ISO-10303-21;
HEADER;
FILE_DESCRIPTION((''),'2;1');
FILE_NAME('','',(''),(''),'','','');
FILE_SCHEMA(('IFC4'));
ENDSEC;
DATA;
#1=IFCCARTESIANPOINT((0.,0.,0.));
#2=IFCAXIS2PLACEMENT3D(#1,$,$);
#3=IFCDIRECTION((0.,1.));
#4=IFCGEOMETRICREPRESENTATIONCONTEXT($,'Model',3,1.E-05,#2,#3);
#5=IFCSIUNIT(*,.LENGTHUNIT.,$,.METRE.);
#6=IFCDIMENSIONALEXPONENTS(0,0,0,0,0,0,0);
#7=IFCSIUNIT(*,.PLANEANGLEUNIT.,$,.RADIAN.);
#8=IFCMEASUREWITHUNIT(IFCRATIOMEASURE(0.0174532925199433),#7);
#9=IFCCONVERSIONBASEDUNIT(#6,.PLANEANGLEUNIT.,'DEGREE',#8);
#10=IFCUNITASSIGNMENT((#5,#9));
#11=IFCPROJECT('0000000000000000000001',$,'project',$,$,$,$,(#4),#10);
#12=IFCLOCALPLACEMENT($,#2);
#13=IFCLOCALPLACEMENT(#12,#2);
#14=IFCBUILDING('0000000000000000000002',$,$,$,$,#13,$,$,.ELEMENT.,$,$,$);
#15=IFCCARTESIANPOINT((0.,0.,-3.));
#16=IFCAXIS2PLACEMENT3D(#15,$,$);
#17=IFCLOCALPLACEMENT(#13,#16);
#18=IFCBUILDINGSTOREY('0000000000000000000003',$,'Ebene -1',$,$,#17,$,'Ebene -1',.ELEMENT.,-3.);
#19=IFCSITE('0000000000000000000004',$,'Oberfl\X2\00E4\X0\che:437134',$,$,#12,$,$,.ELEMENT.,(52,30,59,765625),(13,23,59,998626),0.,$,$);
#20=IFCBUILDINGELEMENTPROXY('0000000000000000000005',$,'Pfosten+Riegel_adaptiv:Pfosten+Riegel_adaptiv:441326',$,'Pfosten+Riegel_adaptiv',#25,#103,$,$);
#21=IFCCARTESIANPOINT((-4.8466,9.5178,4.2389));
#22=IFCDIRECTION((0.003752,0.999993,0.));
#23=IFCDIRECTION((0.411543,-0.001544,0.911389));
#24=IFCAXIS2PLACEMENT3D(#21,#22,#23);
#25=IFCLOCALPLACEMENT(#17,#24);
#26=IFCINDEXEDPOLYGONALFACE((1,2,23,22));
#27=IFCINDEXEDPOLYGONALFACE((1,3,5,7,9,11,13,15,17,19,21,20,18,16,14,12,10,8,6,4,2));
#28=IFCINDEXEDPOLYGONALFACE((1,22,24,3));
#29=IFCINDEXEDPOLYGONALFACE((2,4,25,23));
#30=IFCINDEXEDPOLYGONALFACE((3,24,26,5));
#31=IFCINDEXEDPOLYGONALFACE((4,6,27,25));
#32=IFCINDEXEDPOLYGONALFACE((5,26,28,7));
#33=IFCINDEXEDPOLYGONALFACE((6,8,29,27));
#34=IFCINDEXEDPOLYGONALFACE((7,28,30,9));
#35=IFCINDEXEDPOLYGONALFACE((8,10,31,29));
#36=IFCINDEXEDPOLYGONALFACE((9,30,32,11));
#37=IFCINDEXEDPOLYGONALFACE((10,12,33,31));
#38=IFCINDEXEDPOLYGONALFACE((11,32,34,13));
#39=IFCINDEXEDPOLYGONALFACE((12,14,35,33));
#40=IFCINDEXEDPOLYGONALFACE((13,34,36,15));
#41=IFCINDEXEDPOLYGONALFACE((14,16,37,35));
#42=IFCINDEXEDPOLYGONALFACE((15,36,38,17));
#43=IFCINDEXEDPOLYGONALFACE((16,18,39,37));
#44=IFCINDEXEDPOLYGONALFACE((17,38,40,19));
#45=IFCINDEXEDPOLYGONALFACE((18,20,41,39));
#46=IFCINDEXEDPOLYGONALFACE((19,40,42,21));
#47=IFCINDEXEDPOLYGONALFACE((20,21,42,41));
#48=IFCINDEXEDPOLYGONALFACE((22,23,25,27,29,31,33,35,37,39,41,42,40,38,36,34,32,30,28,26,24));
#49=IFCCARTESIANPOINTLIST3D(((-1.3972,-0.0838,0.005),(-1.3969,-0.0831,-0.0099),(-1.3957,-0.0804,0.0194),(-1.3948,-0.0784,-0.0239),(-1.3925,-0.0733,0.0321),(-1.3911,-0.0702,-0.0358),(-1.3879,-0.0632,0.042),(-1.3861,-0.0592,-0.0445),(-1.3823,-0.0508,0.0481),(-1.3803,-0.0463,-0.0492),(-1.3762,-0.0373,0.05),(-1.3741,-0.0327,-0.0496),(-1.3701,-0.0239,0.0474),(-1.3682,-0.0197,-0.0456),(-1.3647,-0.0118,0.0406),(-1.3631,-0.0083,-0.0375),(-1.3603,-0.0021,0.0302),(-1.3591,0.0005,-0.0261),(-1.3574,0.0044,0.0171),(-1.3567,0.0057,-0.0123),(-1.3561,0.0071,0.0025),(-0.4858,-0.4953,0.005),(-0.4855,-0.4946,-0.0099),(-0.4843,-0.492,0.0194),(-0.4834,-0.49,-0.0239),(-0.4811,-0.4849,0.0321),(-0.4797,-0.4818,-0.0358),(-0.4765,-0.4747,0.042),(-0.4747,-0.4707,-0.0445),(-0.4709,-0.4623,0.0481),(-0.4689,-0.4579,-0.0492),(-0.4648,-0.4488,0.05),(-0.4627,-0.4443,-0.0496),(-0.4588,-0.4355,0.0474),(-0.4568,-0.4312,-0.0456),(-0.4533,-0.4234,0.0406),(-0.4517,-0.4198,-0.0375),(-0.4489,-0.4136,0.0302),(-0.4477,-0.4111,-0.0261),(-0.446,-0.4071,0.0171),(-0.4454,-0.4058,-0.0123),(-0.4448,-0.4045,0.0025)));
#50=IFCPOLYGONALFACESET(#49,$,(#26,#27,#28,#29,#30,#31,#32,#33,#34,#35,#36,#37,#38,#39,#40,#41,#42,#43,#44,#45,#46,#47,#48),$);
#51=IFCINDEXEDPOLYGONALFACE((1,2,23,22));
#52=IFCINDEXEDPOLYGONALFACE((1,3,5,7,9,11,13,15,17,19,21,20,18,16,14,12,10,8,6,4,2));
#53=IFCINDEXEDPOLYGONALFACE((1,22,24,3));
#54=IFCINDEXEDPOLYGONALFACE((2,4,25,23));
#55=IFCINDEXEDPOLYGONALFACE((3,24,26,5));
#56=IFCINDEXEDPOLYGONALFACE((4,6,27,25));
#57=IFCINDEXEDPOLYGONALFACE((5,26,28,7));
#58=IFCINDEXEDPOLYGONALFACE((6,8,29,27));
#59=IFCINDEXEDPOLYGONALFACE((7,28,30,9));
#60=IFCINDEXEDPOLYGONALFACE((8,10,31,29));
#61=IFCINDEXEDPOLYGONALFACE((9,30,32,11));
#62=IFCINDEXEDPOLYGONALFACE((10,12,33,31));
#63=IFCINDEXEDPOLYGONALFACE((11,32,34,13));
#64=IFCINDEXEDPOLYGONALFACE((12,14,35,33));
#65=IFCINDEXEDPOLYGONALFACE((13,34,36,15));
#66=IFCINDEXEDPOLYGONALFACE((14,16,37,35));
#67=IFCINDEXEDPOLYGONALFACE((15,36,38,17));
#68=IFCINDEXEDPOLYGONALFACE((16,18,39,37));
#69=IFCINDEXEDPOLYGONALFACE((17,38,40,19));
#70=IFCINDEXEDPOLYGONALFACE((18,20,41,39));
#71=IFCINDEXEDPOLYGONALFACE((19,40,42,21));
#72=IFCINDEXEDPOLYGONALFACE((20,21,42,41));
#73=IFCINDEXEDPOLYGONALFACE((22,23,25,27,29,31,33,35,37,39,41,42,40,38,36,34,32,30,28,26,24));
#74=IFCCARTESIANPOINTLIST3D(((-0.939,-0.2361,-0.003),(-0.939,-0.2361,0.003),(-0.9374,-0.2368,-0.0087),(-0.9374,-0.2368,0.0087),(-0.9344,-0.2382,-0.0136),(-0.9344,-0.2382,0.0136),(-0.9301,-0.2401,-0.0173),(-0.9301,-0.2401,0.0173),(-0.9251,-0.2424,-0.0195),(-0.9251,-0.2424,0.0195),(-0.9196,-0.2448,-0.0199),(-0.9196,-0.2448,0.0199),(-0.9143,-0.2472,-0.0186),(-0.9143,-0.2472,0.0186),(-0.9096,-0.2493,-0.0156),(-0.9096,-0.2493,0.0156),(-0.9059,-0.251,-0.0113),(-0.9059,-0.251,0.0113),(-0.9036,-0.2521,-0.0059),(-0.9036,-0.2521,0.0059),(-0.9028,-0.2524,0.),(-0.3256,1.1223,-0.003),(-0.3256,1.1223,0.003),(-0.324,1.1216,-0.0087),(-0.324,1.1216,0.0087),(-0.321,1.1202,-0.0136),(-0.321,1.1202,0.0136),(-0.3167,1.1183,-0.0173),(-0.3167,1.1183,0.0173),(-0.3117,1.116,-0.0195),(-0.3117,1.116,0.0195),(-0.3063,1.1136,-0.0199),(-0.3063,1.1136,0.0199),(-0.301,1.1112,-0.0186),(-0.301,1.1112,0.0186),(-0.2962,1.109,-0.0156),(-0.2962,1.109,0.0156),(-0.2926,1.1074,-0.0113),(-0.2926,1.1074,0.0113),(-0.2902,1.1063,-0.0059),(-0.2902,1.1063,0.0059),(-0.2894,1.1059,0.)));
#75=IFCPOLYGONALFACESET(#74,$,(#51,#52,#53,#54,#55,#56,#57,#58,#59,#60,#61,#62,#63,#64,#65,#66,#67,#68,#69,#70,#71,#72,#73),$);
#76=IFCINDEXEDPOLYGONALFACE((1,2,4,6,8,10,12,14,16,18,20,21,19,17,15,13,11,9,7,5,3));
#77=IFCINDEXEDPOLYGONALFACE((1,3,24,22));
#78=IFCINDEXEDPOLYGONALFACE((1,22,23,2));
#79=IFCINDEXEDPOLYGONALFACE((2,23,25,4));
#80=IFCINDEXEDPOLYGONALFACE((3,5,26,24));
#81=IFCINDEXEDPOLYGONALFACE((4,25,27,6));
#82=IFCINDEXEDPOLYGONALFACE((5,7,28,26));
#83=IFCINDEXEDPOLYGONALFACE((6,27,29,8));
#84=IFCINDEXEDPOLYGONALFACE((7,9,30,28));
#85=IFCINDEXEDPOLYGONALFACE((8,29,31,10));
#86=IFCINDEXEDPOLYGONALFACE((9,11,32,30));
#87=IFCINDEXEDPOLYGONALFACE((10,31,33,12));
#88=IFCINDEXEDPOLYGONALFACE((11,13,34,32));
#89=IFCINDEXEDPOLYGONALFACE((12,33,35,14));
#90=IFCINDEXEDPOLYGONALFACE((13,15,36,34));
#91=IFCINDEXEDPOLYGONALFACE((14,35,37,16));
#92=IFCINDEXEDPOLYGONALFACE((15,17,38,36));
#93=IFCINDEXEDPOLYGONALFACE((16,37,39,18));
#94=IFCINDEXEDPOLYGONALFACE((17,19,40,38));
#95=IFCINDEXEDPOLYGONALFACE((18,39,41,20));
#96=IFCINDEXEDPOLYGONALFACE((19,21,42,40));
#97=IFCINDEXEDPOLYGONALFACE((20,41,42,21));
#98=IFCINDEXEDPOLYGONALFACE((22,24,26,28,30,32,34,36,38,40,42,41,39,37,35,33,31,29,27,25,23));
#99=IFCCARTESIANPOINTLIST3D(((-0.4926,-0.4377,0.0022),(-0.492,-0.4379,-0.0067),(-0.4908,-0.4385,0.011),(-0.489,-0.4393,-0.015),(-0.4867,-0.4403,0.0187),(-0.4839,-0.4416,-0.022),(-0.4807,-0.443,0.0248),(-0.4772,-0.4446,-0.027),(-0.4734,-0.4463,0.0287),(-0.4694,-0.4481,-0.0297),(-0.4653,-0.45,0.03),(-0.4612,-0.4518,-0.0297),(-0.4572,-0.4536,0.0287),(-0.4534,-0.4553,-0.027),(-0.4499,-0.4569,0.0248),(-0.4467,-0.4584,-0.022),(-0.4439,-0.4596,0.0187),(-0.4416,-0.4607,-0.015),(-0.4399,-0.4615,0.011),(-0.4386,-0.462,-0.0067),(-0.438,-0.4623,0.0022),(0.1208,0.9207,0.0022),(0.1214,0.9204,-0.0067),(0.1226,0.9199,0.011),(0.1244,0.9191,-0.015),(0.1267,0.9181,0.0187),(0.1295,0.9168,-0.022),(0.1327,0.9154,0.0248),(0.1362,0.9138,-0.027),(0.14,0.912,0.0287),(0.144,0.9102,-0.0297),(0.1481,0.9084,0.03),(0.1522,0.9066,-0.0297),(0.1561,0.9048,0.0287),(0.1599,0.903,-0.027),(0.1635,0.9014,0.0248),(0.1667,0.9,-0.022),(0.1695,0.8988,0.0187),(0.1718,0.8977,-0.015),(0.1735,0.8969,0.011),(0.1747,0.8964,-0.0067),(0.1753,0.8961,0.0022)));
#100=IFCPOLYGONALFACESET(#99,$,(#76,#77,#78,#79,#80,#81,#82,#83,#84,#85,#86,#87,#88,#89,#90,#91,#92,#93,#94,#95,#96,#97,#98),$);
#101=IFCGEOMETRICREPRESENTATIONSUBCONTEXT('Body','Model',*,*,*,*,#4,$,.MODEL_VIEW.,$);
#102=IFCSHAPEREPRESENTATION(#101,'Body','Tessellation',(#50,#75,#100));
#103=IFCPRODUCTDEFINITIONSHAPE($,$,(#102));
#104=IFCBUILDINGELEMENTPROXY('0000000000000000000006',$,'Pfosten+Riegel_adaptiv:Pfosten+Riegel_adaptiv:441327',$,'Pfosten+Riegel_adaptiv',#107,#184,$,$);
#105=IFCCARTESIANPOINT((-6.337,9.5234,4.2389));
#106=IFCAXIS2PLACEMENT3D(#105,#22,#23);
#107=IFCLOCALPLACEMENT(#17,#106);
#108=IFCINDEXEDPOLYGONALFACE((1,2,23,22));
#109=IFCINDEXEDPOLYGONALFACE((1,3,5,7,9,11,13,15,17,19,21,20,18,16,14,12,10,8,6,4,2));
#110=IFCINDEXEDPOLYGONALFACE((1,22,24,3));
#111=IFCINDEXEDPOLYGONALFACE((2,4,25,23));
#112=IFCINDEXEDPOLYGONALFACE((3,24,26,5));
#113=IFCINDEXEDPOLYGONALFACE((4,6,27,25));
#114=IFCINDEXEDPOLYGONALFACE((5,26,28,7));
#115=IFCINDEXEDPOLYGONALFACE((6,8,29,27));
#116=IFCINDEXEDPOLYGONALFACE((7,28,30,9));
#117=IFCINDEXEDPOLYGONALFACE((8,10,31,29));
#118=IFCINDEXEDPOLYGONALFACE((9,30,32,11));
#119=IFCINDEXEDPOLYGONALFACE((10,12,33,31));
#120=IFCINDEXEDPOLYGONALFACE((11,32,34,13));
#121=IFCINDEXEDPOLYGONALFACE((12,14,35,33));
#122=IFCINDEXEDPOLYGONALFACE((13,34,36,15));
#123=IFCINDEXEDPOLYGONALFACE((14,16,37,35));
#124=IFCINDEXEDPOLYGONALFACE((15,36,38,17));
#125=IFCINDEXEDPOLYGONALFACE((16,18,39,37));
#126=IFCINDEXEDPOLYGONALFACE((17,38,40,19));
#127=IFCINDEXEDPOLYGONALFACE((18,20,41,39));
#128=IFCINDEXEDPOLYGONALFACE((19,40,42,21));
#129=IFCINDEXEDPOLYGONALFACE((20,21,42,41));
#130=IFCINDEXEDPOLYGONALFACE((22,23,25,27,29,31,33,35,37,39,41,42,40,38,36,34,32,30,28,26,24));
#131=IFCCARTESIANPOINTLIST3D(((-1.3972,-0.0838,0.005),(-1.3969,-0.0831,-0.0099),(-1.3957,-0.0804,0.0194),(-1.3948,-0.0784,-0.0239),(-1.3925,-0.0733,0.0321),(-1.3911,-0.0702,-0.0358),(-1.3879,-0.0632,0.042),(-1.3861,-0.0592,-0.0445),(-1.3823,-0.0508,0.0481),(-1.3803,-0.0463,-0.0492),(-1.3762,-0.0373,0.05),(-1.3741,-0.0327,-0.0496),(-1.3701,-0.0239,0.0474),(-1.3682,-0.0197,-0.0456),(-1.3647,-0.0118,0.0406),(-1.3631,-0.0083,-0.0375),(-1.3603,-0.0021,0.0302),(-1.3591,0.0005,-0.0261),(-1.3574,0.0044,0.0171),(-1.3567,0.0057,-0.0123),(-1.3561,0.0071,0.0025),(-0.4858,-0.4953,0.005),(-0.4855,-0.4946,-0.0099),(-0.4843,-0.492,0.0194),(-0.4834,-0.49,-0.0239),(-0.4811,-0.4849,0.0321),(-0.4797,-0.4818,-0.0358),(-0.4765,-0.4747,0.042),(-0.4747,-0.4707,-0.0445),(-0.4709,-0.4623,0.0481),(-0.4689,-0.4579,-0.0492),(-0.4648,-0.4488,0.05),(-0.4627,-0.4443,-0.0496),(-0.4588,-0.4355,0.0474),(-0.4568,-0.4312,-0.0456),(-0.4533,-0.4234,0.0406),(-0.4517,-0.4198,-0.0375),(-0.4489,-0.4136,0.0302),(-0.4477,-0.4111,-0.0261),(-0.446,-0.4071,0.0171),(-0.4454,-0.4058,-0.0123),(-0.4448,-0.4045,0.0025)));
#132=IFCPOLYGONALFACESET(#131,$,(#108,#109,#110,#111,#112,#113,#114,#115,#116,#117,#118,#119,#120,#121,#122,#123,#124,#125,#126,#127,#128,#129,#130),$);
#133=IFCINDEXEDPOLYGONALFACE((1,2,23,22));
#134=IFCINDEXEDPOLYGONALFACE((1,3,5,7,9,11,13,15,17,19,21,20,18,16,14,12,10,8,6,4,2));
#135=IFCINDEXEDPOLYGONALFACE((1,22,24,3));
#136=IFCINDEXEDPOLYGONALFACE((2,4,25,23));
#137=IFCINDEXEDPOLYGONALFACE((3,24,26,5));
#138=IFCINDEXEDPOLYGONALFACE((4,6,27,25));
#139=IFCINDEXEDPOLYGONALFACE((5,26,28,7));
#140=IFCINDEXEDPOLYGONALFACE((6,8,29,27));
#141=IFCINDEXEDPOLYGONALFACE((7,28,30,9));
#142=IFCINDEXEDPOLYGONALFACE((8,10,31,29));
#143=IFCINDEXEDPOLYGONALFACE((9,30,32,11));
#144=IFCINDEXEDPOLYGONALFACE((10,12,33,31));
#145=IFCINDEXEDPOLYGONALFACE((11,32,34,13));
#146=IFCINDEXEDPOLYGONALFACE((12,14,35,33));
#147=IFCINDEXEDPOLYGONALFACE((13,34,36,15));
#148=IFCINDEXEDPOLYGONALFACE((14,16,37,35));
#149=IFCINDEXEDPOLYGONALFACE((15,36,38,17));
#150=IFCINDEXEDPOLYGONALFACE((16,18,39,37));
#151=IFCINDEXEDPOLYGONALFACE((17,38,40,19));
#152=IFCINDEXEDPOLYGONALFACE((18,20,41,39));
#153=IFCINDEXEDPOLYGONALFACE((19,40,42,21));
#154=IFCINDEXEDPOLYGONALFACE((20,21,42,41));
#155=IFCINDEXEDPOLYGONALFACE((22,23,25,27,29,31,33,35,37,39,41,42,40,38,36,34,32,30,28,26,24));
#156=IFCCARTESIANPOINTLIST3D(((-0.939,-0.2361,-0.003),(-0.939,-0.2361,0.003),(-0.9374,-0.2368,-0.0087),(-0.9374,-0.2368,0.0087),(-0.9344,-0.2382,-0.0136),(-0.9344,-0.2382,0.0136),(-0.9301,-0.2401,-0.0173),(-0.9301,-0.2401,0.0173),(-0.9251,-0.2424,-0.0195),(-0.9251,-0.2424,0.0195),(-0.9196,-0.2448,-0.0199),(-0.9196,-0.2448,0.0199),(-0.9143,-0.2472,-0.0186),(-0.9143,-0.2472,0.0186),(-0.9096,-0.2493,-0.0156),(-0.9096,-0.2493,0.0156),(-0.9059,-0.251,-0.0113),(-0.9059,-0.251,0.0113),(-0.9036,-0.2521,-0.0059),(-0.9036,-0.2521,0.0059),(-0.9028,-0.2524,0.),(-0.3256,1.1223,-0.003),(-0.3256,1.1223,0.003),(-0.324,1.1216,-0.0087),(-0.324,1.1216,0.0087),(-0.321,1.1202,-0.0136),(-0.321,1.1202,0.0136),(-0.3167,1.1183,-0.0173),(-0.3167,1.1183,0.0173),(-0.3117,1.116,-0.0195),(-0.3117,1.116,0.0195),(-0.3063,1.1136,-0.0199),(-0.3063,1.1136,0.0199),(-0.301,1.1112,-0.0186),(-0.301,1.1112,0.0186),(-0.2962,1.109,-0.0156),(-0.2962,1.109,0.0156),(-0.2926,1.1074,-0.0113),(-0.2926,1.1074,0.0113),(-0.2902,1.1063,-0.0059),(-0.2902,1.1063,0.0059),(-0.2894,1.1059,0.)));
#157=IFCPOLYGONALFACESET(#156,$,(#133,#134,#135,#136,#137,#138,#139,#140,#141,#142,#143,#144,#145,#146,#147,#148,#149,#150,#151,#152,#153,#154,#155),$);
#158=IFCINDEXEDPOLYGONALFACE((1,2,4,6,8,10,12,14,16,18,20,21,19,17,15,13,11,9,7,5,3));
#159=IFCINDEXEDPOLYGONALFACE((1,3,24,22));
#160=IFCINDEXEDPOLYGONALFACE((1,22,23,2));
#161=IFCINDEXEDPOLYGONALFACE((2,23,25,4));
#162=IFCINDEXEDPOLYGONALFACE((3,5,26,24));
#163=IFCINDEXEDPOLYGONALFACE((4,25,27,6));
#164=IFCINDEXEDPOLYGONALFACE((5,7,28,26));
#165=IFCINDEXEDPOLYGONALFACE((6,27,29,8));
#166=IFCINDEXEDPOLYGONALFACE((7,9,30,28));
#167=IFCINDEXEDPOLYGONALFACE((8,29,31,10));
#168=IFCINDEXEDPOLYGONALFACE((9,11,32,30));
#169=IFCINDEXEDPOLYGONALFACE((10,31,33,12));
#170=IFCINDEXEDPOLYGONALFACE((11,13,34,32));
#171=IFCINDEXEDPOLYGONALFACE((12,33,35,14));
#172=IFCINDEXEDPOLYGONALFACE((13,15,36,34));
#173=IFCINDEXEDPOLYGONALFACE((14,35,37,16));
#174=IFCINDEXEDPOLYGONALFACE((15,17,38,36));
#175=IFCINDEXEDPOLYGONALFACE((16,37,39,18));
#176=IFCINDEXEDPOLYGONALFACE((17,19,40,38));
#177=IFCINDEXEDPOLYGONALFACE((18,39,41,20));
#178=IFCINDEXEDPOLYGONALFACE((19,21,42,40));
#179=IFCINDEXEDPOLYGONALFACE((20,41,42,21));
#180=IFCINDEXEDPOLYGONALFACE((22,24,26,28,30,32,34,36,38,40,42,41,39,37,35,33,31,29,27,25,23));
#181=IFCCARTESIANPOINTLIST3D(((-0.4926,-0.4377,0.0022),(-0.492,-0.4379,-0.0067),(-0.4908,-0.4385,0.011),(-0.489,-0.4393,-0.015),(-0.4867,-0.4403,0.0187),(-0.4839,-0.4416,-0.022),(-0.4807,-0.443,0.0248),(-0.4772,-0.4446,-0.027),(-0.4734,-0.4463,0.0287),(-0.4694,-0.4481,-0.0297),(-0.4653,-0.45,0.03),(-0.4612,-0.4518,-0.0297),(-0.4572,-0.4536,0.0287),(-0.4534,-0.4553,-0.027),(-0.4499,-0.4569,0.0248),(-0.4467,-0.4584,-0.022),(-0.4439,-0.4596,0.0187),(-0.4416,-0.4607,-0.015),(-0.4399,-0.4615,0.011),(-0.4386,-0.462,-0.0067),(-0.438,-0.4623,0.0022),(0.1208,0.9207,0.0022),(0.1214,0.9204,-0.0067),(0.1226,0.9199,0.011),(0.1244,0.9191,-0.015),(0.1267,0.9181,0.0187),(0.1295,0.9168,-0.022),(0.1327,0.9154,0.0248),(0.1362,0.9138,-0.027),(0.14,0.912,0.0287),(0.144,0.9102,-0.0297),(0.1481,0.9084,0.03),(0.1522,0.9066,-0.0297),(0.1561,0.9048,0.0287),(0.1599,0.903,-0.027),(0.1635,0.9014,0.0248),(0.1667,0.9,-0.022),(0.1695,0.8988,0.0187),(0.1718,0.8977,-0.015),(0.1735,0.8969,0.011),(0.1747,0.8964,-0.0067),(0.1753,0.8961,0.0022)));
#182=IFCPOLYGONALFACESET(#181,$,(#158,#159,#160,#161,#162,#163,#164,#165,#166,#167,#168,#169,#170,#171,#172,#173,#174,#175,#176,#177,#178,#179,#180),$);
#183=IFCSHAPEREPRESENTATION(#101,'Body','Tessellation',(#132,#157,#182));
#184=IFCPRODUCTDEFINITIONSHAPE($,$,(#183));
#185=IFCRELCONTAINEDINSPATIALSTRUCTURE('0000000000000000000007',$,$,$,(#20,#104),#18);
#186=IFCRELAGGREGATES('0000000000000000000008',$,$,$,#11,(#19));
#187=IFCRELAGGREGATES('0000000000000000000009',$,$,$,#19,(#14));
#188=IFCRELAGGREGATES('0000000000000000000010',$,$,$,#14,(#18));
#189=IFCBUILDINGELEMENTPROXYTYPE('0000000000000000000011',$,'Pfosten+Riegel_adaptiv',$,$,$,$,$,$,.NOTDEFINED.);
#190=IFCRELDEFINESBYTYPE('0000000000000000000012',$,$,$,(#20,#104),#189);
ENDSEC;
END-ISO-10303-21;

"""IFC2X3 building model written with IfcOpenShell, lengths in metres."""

from ifc_helpers import new_model, entity, si_unit, converted_unit, direction, frame, frame_2d, origin, place, context, subcontext, project, spatial, circle, extrude, source, transform, mapped, type_object, type_shapes, element, save


model = new_model("IFC2X3")

# Units and contexts
model_context = context("Model", 3, precision=1e-05, world=origin(), true_north=direction((0.0, 1.0)))
body_context = subcontext(model_context, "Body", "Model", "MODEL_VIEW")
ifc_project = project(units=[si_unit("LENGTHUNIT", "METRE"), converted_unit("PLANEANGLEUNIT", "DEGREE", entity("IfcRatioMeasure", 0.0174532925199433), si_unit("PLANEANGLEUNIT", "RADIAN"), dimensions=[0, 0, 0, 0, 0, 0, 0])], contexts=[model_context])

# Site, building, storey
site_placement = place(None, origin())
site = spatial("IfcSite", under=ifc_project, at=site_placement, Name="Oberfläche:437134", CompositionType="ELEMENT", RefLatitude=(52, 30, 59, 765625), RefLongitude=(13, 23, 59, 998626), RefElevation=0.0)
building_placement = place(site_placement, origin())
building = spatial("IfcBuilding", under=site, at=building_placement, CompositionType="ELEMENT")
storey_placement = place(building_placement, frame((0.0, 0.0, -3.0)))
storey = spatial("IfcBuildingStorey", under=building, at=storey_placement, Name="Ebene -1", LongName="Ebene -1", CompositionType="ELEMENT", Elevation=-3.0)

# Building element proxies
building_element_proxy_type_1 = type_object("IfcBuildingElementProxyType", Name="Pfosten+Riegel_adaptiv", PredefinedType="NOTDEFINED")
shared_shape_1 = source(origin(), body_context, "Body", "SweptSolid", [
    extrude(circle(Radius=0.05, at=frame_2d((0.0, 0.0), x_axis=(1.0, 0.0))), frame((-0.4653, -0.45, 0.0), z_axis=(-0.911389, 0.411546, 0.0), x_axis=(0.16937, 0.375078, -0.911389)), (0.0, 0.0, 1.0), 1.0),
    extrude(circle(Radius=0.02, at=frame_2d((0.0, 0.0), x_axis=(1.0, 0.0))), frame((-0.921, -0.2442, 0.0), z_axis=(0.411546, 0.911389, 0.0), x_axis=(0.911389, -0.411546, 0.0)), (0.0, 0.0, 1.0), 1.4904),
    extrude(circle(Radius=0.03, at=frame_2d((0.0, 0.0), x_axis=(1.0, 0.0))), frame((-0.4653, -0.45, 0.0), z_axis=(0.411546, 0.911389, 0.0), x_axis=(0.0, 0.0, 1.0)), (0.0, 0.0, 1.0), 1.4904),
])
type_shapes(building_element_proxy_type_1, [shared_shape_1])
for number, where, z_axis, x_axis, name in (
    (1, (-4.8466, 9.5178, 4.2389), (0.003752, 0.999993, 0.0), (0.411543, -0.001544, 0.911389), "Pfosten+Riegel_adaptiv:Pfosten+Riegel_adaptiv:441326"),
    (2, (-6.337, 9.5234, 4.2389), (0.003752, 0.999993, 0.0), (0.411543, -0.001544, 0.911389), "Pfosten+Riegel_adaptiv:Pfosten+Riegel_adaptiv:441327"),
):
    element("IfcBuildingElementProxy", number, at=place(storey_placement, frame(where, z_axis=z_axis, x_axis=x_axis)), inside=storey, type_object=building_element_proxy_type_1, Name=name, ObjectType="Pfosten+Riegel_adaptiv", context=body_context, shape_type="MappedRepresentation", body=[
        mapped(shared_shape_1, transform((0.0, 0.0, 0.0), scale=1.0)),
    ])

save(model, "model.ifc")
